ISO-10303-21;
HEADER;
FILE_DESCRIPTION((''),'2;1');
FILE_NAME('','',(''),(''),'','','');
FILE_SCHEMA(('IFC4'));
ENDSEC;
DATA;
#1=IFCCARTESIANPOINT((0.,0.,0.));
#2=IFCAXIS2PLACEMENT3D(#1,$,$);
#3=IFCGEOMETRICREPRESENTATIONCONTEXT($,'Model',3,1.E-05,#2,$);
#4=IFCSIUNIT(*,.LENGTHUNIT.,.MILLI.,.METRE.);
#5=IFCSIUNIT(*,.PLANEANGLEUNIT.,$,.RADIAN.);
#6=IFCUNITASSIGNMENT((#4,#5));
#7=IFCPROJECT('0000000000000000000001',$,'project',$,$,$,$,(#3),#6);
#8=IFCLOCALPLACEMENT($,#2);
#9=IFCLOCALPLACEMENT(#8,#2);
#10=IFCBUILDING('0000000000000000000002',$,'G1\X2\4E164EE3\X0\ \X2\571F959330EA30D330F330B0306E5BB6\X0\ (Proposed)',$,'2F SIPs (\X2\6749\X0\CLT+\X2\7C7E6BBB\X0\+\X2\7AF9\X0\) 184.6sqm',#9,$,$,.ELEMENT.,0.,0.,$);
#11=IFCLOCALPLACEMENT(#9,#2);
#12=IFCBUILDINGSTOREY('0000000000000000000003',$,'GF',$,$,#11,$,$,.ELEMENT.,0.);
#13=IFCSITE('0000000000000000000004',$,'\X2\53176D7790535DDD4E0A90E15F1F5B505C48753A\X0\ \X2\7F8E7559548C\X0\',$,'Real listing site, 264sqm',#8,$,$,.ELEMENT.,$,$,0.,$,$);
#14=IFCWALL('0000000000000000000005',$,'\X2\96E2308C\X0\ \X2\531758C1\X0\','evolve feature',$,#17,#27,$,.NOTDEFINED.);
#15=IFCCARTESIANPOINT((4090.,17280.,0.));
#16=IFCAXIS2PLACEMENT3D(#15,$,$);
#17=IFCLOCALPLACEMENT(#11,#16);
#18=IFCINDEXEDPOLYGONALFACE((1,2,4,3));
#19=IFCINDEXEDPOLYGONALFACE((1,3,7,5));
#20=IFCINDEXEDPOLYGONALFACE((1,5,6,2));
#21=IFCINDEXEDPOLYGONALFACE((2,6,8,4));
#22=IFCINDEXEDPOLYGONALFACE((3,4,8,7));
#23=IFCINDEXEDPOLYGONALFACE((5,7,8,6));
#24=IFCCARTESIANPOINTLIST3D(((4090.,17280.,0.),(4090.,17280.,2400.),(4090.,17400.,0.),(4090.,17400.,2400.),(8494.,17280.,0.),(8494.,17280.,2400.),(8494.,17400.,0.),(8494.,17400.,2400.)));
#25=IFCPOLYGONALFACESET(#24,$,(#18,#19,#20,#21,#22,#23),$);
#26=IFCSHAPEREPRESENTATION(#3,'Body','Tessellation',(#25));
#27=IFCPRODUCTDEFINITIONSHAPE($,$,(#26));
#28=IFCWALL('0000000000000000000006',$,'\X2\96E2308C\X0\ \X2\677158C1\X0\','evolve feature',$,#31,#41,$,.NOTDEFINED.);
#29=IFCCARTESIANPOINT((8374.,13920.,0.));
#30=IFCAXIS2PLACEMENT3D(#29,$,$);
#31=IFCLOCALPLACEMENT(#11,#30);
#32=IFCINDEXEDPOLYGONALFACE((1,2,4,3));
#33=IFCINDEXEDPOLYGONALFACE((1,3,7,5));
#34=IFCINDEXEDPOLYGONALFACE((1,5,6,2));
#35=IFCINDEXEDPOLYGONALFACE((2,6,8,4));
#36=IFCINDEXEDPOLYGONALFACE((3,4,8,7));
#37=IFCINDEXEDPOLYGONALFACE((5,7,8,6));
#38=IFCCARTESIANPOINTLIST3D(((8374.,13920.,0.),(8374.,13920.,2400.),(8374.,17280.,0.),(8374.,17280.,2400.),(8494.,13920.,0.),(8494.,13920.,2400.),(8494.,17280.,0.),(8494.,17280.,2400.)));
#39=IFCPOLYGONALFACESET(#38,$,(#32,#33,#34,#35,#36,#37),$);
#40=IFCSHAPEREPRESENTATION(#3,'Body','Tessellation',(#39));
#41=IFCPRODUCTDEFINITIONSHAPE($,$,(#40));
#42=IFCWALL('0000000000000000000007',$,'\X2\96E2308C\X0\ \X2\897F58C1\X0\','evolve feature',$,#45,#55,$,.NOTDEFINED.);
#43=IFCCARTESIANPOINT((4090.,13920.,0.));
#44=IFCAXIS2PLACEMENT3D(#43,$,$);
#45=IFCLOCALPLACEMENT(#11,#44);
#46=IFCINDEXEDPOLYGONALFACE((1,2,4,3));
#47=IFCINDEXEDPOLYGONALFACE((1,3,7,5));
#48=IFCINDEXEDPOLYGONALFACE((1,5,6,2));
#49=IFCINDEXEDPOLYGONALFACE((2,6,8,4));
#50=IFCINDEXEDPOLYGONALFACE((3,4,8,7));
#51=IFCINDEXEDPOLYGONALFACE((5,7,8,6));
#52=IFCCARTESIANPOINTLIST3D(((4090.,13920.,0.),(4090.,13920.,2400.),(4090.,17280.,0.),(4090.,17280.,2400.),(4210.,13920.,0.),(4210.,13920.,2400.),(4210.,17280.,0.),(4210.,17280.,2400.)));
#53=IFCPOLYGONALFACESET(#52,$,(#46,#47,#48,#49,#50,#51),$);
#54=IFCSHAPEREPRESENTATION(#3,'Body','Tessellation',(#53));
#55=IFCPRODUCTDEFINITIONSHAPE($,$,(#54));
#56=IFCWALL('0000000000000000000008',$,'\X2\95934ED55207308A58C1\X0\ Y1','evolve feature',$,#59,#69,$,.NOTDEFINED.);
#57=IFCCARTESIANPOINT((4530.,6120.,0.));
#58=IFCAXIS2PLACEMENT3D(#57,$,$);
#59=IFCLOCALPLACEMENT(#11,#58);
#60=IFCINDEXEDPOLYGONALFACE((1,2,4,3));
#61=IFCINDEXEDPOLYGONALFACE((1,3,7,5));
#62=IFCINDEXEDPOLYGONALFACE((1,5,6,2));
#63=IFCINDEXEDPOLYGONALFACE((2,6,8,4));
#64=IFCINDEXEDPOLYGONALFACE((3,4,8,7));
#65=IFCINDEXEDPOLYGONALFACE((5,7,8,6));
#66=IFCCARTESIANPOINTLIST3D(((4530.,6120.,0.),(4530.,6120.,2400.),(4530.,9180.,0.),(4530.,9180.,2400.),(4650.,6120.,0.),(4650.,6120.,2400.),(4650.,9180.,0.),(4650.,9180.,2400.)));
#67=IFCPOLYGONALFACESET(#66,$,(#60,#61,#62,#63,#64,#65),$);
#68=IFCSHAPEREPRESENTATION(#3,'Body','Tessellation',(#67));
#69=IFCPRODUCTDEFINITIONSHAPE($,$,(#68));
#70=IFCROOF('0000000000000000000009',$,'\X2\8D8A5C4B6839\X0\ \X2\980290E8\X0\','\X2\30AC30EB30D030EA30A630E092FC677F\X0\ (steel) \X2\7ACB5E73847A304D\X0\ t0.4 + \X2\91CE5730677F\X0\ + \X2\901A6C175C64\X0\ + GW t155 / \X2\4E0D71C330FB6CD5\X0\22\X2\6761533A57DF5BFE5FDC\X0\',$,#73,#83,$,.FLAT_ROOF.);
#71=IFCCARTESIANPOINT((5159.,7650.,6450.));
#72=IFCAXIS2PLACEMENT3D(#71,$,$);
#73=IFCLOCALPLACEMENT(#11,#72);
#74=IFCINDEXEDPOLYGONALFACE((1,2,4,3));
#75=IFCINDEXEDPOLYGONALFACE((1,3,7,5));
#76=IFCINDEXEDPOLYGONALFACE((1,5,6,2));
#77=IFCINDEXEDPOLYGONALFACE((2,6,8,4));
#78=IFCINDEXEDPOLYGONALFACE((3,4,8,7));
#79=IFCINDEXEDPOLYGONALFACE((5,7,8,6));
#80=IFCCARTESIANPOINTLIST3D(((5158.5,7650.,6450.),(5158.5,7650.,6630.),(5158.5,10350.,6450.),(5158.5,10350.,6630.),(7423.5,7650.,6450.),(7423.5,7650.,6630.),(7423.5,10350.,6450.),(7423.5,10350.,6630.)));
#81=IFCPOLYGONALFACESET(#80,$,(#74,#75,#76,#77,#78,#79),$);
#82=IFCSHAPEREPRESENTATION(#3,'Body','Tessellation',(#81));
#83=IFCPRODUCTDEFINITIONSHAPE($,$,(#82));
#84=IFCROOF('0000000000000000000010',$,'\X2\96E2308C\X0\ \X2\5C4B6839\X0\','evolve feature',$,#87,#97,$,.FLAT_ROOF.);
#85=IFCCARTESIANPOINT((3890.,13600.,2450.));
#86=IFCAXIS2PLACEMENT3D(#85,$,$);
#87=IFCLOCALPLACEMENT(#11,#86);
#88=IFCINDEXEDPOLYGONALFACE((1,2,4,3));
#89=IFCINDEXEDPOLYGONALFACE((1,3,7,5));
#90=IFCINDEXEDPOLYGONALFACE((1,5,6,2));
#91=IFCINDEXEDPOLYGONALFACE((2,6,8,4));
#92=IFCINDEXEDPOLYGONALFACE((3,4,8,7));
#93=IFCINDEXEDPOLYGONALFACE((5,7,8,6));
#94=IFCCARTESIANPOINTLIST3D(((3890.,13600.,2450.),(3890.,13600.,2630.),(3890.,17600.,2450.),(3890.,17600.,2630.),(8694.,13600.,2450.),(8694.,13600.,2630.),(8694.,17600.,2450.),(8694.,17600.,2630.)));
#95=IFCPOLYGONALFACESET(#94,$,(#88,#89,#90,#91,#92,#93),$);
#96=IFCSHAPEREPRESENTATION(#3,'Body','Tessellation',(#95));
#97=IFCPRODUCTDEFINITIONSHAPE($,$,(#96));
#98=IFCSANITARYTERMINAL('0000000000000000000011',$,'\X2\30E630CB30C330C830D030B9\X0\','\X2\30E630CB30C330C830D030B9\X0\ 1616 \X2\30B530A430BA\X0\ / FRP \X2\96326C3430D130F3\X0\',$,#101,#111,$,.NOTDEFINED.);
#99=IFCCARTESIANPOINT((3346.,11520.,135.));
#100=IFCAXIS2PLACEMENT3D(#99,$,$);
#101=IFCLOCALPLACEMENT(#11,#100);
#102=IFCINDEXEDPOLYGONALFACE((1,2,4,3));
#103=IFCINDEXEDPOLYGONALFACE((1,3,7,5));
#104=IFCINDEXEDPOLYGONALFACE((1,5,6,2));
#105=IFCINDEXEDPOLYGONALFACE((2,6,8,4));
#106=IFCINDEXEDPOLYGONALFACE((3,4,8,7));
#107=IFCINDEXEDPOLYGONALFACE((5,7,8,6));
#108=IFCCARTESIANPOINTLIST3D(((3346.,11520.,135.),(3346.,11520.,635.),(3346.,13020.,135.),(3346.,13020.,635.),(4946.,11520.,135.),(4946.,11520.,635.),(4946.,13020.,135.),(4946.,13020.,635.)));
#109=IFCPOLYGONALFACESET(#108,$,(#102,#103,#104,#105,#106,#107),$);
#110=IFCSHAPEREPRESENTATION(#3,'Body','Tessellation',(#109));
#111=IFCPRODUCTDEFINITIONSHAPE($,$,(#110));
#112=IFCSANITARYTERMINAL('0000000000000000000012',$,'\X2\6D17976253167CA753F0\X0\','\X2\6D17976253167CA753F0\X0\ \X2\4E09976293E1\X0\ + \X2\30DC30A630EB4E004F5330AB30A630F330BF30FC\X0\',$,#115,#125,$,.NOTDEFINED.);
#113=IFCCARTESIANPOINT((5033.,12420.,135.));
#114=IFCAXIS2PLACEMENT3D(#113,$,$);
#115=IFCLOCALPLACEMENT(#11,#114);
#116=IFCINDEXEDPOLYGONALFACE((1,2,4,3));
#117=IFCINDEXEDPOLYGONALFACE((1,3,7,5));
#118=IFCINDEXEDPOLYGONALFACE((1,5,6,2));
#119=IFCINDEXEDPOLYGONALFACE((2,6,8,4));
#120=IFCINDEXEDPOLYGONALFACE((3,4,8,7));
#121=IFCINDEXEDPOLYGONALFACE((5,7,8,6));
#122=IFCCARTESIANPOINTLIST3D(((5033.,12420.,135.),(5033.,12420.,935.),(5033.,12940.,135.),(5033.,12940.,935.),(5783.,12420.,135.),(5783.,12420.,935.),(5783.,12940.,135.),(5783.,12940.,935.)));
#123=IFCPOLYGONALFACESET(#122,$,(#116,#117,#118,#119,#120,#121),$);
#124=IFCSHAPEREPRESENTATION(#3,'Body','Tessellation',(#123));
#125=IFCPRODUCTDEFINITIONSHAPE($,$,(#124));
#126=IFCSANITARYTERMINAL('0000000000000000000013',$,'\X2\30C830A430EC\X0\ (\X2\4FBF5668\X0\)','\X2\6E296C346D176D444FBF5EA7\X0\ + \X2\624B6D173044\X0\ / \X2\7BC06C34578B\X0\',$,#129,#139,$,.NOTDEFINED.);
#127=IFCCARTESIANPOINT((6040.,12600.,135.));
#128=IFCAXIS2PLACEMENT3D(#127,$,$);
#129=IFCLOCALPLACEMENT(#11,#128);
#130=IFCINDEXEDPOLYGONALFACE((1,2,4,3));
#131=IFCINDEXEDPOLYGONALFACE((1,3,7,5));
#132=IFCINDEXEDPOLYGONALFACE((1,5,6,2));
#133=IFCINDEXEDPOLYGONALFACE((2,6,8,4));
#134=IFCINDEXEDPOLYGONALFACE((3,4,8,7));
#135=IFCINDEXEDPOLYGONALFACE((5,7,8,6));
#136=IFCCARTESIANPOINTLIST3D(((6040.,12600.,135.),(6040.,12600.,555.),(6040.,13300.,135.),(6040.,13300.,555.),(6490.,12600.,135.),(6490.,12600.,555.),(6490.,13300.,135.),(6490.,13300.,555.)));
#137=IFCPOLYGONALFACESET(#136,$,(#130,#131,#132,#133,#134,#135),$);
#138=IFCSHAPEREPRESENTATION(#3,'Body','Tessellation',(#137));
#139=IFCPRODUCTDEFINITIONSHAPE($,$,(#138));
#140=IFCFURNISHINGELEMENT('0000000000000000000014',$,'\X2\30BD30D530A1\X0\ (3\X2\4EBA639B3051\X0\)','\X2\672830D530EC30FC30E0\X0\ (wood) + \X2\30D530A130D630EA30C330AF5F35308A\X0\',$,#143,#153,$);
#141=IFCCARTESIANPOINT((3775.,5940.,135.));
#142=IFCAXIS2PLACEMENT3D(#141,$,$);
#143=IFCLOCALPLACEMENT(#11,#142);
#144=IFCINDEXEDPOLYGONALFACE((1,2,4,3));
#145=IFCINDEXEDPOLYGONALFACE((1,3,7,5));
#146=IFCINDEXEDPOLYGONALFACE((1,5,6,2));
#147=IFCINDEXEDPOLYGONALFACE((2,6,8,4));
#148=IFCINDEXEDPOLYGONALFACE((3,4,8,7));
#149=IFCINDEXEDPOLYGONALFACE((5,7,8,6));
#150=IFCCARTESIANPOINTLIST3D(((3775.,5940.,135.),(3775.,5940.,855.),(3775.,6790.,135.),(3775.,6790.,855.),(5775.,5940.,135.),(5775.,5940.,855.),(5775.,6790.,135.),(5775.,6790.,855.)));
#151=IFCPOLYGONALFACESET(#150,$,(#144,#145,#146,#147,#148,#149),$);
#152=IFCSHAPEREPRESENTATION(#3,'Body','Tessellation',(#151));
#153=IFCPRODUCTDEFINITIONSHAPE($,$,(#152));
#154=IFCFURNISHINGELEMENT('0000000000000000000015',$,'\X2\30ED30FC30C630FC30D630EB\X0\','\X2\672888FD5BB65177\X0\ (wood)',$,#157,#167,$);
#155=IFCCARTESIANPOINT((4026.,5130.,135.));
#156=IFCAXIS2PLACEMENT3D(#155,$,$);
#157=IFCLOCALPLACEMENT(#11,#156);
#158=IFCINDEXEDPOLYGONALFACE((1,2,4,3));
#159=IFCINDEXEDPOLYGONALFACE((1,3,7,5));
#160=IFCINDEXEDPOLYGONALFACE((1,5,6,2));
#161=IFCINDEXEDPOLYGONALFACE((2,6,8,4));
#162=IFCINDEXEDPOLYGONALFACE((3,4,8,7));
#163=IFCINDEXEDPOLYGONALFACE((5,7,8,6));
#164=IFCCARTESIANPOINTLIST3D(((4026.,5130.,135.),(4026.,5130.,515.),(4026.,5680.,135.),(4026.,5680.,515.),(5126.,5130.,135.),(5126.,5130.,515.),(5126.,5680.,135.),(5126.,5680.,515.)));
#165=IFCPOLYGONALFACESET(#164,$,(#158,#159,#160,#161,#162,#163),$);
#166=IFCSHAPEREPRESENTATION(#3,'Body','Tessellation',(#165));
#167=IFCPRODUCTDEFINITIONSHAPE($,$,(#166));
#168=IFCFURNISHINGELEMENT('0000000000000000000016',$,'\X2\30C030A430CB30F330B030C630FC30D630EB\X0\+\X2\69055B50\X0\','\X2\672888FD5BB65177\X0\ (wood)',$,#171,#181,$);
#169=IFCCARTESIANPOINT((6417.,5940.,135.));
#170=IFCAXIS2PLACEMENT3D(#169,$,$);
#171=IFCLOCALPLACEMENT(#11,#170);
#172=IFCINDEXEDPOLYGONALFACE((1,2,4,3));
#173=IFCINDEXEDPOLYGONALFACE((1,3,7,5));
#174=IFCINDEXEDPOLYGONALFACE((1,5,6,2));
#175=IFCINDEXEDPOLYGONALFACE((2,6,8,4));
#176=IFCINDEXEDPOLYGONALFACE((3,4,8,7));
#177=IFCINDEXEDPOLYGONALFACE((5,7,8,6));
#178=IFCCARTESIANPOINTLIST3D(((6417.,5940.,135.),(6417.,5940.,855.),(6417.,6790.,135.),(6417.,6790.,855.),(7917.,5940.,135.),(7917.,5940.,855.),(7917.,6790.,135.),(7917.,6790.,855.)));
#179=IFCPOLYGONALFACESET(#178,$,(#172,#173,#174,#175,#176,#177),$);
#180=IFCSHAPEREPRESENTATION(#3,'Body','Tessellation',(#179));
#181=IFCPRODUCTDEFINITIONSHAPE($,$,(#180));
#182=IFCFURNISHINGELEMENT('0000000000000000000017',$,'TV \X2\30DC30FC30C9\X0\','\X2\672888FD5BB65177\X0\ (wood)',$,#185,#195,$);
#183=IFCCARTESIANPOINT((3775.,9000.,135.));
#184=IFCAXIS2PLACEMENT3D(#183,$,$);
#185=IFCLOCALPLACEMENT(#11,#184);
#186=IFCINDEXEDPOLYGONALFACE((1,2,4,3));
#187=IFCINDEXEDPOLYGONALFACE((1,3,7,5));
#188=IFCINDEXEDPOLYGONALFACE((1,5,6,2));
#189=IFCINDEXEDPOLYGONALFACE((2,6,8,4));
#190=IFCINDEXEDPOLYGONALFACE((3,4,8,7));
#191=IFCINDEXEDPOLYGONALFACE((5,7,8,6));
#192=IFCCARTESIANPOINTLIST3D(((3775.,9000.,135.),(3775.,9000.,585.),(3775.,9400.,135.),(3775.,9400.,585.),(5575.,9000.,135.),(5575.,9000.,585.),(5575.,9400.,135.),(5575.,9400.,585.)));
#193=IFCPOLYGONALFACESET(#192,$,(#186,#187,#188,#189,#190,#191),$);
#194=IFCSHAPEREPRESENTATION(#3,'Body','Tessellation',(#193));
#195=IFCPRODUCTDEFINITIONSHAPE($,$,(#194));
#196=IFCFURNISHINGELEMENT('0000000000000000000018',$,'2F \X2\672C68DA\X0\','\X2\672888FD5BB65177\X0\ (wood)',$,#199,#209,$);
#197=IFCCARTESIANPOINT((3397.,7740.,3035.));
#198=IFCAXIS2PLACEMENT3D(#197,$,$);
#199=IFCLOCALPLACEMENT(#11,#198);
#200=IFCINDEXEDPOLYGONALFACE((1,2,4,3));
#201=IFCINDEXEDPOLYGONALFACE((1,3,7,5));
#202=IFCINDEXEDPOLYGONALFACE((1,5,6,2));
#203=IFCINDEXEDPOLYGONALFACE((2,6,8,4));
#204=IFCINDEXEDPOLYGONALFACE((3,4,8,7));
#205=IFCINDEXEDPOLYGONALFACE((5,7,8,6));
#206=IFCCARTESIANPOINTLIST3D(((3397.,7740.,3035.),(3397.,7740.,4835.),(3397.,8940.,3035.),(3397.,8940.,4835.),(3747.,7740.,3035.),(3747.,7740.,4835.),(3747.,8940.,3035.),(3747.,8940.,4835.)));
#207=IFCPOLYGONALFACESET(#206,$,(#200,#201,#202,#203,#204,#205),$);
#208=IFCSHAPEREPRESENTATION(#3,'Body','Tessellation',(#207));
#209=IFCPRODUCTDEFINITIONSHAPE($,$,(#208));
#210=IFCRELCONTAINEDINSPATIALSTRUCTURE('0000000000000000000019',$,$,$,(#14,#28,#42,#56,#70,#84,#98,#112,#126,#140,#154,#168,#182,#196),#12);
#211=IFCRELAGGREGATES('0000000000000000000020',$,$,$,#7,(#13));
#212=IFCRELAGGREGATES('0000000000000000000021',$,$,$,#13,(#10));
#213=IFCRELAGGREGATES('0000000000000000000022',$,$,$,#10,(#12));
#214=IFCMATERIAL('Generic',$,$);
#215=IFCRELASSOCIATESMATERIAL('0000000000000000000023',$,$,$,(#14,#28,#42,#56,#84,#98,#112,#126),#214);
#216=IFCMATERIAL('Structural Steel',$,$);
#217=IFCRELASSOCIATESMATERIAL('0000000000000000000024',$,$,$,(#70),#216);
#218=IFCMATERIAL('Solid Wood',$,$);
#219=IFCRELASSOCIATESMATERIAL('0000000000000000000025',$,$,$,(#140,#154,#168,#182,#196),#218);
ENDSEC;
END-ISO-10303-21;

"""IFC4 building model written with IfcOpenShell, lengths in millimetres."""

from ifc_helpers import new_model, si_unit, frame, frame_2d, origin, place, context, project, spatial, rectangle, extrude, material, element, save


model = new_model("IFC4")

# Units and contexts
model_context = context("Model", 3, precision=1e-05, world=origin())
ifc_project = project(units=[si_unit("LENGTHUNIT", "METRE", prefix="MILLI"), si_unit("PLANEANGLEUNIT", "RADIAN")], contexts=[model_context])

# Site, building, storey
site_placement = place(None, origin())
site = spatial("IfcSite", under=ifc_project, at=site_placement, Name="北海道川上郡弟子屈町 美留和", ObjectType="Real listing site, 264sqm", CompositionType="ELEMENT", RefElevation=0.0)
building_placement = place(site_placement, origin())
building = spatial("IfcBuilding", under=site, at=building_placement, Name="G1世代 土間リビングの家 (Proposed)", ObjectType="2F SIPs (杉CLT+籾殻+竹) 184.6sqm", CompositionType="ELEMENT", ElevationOfRefHeight=0.0, ElevationOfTerrain=0.0)
storey_placement = place(building_placement, origin())
storey = spatial("IfcBuildingStorey", under=building, at=storey_placement, Name="GF", CompositionType="ELEMENT", Elevation=0.0)

# Shared definitions
ifc_material_1 = material(Name="Generic")

# Shared definitions
ifc_material_2 = material(Name="Solid Wood")

# Walls
wall_1_placement = place(storey_placement, frame((4090.0, 17280.0, 0.0)))
element("IfcWall", 1, at=wall_1_placement, inside=storey, material=ifc_material_1, Name="離れ 北壁", Description="evolve feature", PredefinedType="NOTDEFINED", context=model_context, shape_type="SweptSolid", body=[
    extrude(rectangle(XDim=4404.0, YDim=120.0, at=frame_2d((2202.0, 60.0))), frame((4090.0, 17280.0, 0.0)), (0.0, 0.0, 1.0), 2400.0),
])
wall_2_placement = place(storey_placement, frame((8374.0, 13920.0, 0.0)))
element("IfcWall", 2, at=wall_2_placement, inside=storey, material=ifc_material_1, Name="離れ 東壁", Description="evolve feature", PredefinedType="NOTDEFINED", context=model_context, shape_type="SweptSolid", body=[
    extrude(rectangle(XDim=120.0, YDim=3360.0, at=frame_2d((60.0, 1680.0))), frame((8374.0, 13920.0, 0.0)), (0.0, 0.0, 1.0), 2400.0),
])
wall_3_placement = place(storey_placement, frame((4090.0, 13920.0, 0.0)))
element("IfcWall", 3, at=wall_3_placement, inside=storey, material=ifc_material_1, Name="離れ 西壁", Description="evolve feature", PredefinedType="NOTDEFINED", context=model_context, shape_type="SweptSolid", body=[
    extrude(rectangle(XDim=120.0, YDim=3360.0, at=frame_2d((60.0, 1680.0))), frame((4090.0, 13920.0, 0.0)), (0.0, 0.0, 1.0), 2400.0),
])
wall_4_placement = place(storey_placement, frame((4530.0, 6120.0, 0.0)))
element("IfcWall", 4, at=wall_4_placement, inside=storey, material=ifc_material_1, Name="間仕切り壁 Y1", Description="evolve feature", PredefinedType="NOTDEFINED", context=model_context, shape_type="SweptSolid", body=[
    extrude(rectangle(XDim=120.0, YDim=3060.0, at=frame_2d((60.0, 1530.0))), frame((4530.0, 6120.0, 0.0)), (0.0, 0.0, 1.0), 2400.0),
])

# Roofs
ifc_material_3 = material(Name="Structural Steel")
roof_1_placement = place(storey_placement, frame((5159.0, 7650.0, 6450.0)))
element("IfcRoof", 5, at=roof_1_placement, inside=storey, material=ifc_material_3, Name="越屋根 頂部", Description="ガルバリウム鋼板 (steel) 立平葺き t0.4 + 野地板 + 通気層 + GW t155 / 不燃・法22条区域対応", PredefinedType="FLAT_ROOF", context=model_context, shape_type="SweptSolid", body=[
    extrude(rectangle(XDim=2265.0, YDim=2700.0, at=frame_2d((1132.0, 1350.0))), frame((5159.0, 7650.0, 6450.0)), (0.0, 0.0, 1.0), 180.0),
])
roof_2_placement = place(storey_placement, frame((3890.0, 13600.0, 2450.0)))
element("IfcRoof", 6, at=roof_2_placement, inside=storey, material=ifc_material_1, Name="離れ 屋根", Description="evolve feature", PredefinedType="FLAT_ROOF", context=model_context, shape_type="SweptSolid", body=[
    extrude(rectangle(XDim=4804.0, YDim=4000.0, at=frame_2d((2402.0, 2000.0))), frame((3890.0, 13600.0, 2450.0)), (0.0, 0.0, 1.0), 180.0),
])

# Sanitary terminals
sanitary_terminal_1_placement = place(storey_placement, frame((3346.0, 11520.0, 135.0)))
element("IfcSanitaryTerminal", 7, at=sanitary_terminal_1_placement, inside=storey, material=ifc_material_1, Name="ユニットバス", Description="ユニットバス 1616 サイズ / FRP 防水パン", PredefinedType="NOTDEFINED", context=model_context, shape_type="SweptSolid", body=[
    extrude(rectangle(XDim=1600.0, YDim=1500.0, at=frame_2d((800.0, 750.0))), frame((3346.0, 11520.0, 135.0)), (0.0, 0.0, 1.0), 500.0),
])
sanitary_terminal_2_placement = place(storey_placement, frame((5033.0, 12420.0, 135.0)))
element("IfcSanitaryTerminal", 8, at=sanitary_terminal_2_placement, inside=storey, material=ifc_material_1, Name="洗面化粧台", Description="洗面化粧台 三面鏡 + ボウル一体カウンター", PredefinedType="NOTDEFINED", context=model_context, shape_type="SweptSolid", body=[
    extrude(rectangle(XDim=750.0, YDim=520.0, at=frame_2d((375.0, 260.0))), frame((5033.0, 12420.0, 135.0)), (0.0, 0.0, 1.0), 800.0),
])
sanitary_terminal_3_placement = place(storey_placement, frame((6040.0, 12600.0, 135.0)))
element("IfcSanitaryTerminal", 9, at=sanitary_terminal_3_placement, inside=storey, material=ifc_material_1, Name="トイレ (便器)", Description="温水洗浄便座 + 手洗い / 節水型", PredefinedType="NOTDEFINED", context=model_context, shape_type="SweptSolid", body=[
    extrude(rectangle(XDim=450.0, YDim=700.0, at=frame_2d((225.0, 350.0))), frame((6040.0, 12600.0, 135.0)), (0.0, 0.0, 1.0), 420.0),
])

# Furnishing elements
furnishing_1_placement = place(storey_placement, frame((3775.0, 5940.0, 135.0)))
element("IfcFurnishingElement", 10, at=furnishing_1_placement, inside=storey, material=ifc_material_2, Name="ソファ (3人掛け)", Description="木フレーム (wood) + ファブリック張り", context=model_context, shape_type="SweptSolid", body=[
    extrude(rectangle(XDim=2000.0, YDim=850.0, at=frame_2d((1000.0, 425.0))), frame((3775.0, 5940.0, 135.0)), (0.0, 0.0, 1.0), 720.0),
])
furnishing_2_placement = place(storey_placement, frame((4026.0, 5130.0, 135.0)))
element("IfcFurnishingElement", 11, at=furnishing_2_placement, inside=storey, material=ifc_material_2, Name="ローテーブル", Description="木製家具 (wood)", context=model_context, shape_type="SweptSolid", body=[
    extrude(rectangle(XDim=1100.0, YDim=550.0, at=frame_2d((550.0, 275.0))), frame((4026.0, 5130.0, 135.0)), (0.0, 0.0, 1.0), 380.0),
])
furnishing_3_placement = place(storey_placement, frame((6417.0, 5940.0, 135.0)))
element("IfcFurnishingElement", 12, at=furnishing_3_placement, inside=storey, material=ifc_material_2, Name="ダイニングテーブル+椅子", Description="木製家具 (wood)", context=model_context, shape_type="SweptSolid", body=[
    extrude(rectangle(XDim=1500.0, YDim=850.0, at=frame_2d((750.0, 425.0))), frame((6417.0, 5940.0, 135.0)), (0.0, 0.0, 1.0), 720.0),
])
furnishing_4_placement = place(storey_placement, frame((3775.0, 9000.0, 135.0)))
element("IfcFurnishingElement", 13, at=furnishing_4_placement, inside=storey, material=ifc_material_2, Name="TV ボード", Description="木製家具 (wood)", context=model_context, shape_type="SweptSolid", body=[
    extrude(rectangle(XDim=1800.0, YDim=400.0, at=frame_2d((900.0, 200.0))), frame((3775.0, 9000.0, 135.0)), (0.0, 0.0, 1.0), 450.0),
])
furnishing_5_placement = place(storey_placement, frame((3397.0, 7740.0, 3035.0)))
element("IfcFurnishingElement", 14, at=furnishing_5_placement, inside=storey, material=ifc_material_2, Name="2F 本棚", Description="木製家具 (wood)", context=model_context, shape_type="SweptSolid", body=[
    extrude(rectangle(XDim=350.0, YDim=1200.0, at=frame_2d((175.0, 600.0))), frame((3397.0, 7740.0, 3035.0)), (0.0, 0.0, 1.0), 1800.0),
])

save(model, "model.ifc")
